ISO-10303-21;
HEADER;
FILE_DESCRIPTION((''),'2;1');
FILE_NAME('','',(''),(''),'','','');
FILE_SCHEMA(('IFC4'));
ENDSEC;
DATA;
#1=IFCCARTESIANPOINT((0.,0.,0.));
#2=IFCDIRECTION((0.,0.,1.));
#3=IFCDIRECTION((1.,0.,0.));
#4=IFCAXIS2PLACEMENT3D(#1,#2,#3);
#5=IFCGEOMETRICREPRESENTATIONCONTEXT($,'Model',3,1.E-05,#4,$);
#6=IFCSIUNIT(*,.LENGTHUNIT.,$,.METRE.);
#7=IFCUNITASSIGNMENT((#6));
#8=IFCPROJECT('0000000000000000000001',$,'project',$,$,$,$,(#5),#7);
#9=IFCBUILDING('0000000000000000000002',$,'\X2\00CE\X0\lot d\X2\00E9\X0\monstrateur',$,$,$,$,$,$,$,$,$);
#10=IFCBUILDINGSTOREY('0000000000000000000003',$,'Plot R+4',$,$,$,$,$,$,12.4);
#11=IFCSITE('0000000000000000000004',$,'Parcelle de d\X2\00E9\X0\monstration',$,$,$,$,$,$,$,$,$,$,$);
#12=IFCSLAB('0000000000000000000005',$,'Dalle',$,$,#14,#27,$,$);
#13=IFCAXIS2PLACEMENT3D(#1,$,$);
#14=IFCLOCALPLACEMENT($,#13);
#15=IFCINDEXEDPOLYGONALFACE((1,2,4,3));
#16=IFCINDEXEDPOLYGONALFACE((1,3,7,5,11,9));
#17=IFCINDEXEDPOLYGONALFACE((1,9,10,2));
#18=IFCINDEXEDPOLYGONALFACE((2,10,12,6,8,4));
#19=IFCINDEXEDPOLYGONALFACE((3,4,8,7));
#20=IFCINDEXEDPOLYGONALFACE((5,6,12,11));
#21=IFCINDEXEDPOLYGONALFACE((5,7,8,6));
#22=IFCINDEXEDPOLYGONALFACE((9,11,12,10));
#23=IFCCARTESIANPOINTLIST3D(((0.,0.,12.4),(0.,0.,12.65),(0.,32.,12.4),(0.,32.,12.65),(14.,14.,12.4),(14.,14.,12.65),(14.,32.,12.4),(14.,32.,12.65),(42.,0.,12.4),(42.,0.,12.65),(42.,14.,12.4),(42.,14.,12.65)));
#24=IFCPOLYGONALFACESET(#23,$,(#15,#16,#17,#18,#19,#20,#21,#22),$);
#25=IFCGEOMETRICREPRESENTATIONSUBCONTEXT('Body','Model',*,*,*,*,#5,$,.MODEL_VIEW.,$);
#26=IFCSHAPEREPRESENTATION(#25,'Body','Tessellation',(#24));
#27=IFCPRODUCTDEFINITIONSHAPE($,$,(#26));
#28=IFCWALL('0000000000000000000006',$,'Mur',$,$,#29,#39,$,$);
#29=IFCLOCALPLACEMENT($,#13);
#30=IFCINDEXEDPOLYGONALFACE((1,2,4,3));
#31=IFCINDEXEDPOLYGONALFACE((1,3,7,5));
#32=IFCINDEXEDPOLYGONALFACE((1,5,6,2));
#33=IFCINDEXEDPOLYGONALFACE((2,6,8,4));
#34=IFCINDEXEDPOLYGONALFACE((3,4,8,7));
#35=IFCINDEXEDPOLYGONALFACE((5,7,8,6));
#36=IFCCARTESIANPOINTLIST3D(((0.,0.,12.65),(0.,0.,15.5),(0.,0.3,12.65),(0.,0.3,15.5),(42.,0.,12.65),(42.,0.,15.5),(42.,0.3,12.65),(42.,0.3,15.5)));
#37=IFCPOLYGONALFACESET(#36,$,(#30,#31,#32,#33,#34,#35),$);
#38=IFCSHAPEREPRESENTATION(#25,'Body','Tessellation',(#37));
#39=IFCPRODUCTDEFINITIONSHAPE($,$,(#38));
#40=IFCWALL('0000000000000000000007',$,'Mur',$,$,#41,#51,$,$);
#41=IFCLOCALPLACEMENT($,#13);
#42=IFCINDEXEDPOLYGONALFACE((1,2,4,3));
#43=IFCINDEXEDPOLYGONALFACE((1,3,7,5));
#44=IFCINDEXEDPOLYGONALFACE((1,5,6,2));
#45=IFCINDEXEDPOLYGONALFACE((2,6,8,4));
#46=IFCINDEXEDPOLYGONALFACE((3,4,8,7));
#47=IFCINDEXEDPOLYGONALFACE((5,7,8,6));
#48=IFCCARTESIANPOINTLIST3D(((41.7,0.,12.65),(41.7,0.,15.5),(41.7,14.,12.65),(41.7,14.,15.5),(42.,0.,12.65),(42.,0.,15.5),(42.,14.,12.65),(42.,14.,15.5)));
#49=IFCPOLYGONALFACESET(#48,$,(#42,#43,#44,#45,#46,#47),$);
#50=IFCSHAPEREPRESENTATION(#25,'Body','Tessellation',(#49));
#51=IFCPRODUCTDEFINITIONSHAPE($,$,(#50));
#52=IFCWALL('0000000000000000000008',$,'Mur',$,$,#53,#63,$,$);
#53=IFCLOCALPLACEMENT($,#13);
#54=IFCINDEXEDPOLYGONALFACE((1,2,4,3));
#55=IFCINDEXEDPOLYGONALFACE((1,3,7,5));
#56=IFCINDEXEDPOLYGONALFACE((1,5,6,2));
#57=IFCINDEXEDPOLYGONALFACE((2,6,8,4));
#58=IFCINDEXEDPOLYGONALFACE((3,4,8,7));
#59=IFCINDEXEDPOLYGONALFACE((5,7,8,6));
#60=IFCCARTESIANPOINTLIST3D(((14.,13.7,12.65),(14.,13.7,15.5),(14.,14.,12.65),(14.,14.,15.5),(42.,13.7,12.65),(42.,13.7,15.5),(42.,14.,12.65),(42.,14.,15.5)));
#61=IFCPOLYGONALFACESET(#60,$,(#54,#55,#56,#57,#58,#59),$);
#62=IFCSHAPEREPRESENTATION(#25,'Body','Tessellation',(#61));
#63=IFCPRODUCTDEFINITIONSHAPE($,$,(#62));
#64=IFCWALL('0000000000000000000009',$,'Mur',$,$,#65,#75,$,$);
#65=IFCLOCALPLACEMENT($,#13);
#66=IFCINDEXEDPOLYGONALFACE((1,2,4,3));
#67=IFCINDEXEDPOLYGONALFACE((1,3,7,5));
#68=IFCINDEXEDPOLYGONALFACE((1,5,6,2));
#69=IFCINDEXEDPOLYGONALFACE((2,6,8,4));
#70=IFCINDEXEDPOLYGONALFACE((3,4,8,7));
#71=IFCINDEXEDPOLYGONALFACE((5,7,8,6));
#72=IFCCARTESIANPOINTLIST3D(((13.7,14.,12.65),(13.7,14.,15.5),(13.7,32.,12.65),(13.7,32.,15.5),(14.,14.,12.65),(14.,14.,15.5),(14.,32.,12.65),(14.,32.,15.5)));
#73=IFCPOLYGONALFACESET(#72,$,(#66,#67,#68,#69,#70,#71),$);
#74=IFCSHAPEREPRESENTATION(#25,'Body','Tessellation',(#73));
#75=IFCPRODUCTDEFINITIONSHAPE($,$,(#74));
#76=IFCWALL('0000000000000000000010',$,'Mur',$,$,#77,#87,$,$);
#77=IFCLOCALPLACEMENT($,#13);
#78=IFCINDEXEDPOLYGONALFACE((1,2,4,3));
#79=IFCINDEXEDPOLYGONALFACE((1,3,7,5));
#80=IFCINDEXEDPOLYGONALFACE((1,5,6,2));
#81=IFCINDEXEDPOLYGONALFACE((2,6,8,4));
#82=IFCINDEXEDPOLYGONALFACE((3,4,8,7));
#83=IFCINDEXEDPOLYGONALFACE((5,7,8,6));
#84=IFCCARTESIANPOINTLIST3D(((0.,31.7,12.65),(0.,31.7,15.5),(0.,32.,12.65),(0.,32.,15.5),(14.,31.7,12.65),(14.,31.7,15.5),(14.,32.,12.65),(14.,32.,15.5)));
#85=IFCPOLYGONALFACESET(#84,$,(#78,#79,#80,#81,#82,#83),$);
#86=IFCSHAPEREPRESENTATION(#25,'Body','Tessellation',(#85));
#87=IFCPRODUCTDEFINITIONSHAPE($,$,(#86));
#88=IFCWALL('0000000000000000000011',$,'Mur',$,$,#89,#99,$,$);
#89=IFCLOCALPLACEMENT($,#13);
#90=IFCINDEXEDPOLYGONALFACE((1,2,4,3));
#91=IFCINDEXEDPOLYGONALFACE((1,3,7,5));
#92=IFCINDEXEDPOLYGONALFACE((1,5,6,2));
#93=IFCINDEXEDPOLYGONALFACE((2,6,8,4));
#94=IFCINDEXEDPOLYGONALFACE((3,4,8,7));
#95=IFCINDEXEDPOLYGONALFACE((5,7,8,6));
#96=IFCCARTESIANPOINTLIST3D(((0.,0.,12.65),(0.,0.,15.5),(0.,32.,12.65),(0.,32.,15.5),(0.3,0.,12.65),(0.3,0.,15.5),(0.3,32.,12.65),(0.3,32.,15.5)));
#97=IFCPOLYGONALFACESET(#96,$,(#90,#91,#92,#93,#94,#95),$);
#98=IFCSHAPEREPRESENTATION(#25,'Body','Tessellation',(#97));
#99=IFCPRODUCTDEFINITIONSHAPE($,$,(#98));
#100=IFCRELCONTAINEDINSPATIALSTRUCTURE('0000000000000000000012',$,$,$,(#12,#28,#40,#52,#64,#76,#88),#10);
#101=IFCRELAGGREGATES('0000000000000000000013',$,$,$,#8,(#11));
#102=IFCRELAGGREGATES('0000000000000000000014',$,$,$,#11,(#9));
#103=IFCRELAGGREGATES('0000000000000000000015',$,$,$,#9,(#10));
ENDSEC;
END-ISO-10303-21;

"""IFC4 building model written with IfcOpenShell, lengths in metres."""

from ifc_helpers import new_model, si_unit, frame, origin_with_axes, place, context, subcontext, project, spatial, indexed_curve, outline, extrude, element, save


model = new_model("IFC4")

# Units and contexts
model_context = context("Model", 3, precision=1e-05, world=origin_with_axes())
body_context = subcontext(model_context, "Body", "Model", "MODEL_VIEW")
ifc_project = project(units=[si_unit("LENGTHUNIT", "METRE")], contexts=[model_context])

# Site, building, storey
site = spatial("IfcSite", under=ifc_project, Name="Parcelle de démonstration")
building = spatial("IfcBuilding", under=site, Name="Îlot démonstrateur")
storey = spatial("IfcBuildingStorey", under=building, Name="Plot R+4", Elevation=12.4)

# Slab
slab_placement = place(None, frame((0.0, 0.0, 12.4), z_axis=(0.0, 0.0, 1.0), x_axis=(1.0, 0.0, 0.0)))
element("IfcSlab", 1, at=slab_placement, inside=storey, Name="Dalle", context=body_context, shape_type="SweptSolid", body=[
    extrude(outline(indexed_curve([(0.0, 0.0), (42.0, 0.0), (42.0, 14.0), (14.0, 14.0), (14.0, 32.0), (0.0, 32.0)])), None, (0.0, 0.0, 1.0), 0.25),
])

# Walls
wall_1_placement = place(None, frame((0.0, 0.0, 12.65), z_axis=(0.0, 0.0, 1.0), x_axis=(1.0, 0.0, 0.0)))
element("IfcWall", 2, at=wall_1_placement, inside=storey, Name="Mur", context=body_context, shape_type="SweptSolid", body=[
    extrude(outline(indexed_curve([(0.0, 0.0), (0.0, 0.3), (42.0, 0.3), (42.0, 0.0), (0.0, 0.0)], self_intersect=False)), origin_with_axes(), (0.0, 0.0, 1.0), 2.85),
])
wall_2_placement = place(None, frame((42.0, 0.0, 12.65), z_axis=(0.0, 0.0, 1.0), x_axis=(0.0, 1.0, 0.0)))
element("IfcWall", 3, at=wall_2_placement, inside=storey, Name="Mur", context=body_context, shape_type="SweptSolid", body=[
    extrude(outline(indexed_curve([(0.0, 0.0), (0.0, 0.3), (14.0, 0.3), (14.0, 0.0), (0.0, 0.0)], self_intersect=False)), origin_with_axes(), (0.0, 0.0, 1.0), 2.85),
])
wall_3_placement = place(None, frame((42.0, 14.0, 12.65), z_axis=(0.0, 0.0, 1.0), x_axis=(-1.0, 0.0, 0.0)))
element("IfcWall", 4, at=wall_3_placement, inside=storey, Name="Mur", context=body_context, shape_type="SweptSolid", body=[
    extrude(outline(indexed_curve([(0.0, 0.0), (0.0, 0.3), (28.0, 0.3), (28.0, 0.0), (0.0, 0.0)], self_intersect=False)), origin_with_axes(), (0.0, 0.0, 1.0), 2.85),
])
wall_4_placement = place(None, frame((14.0, 14.0, 12.65), z_axis=(0.0, 0.0, 1.0), x_axis=(0.0, 1.0, 0.0)))
element("IfcWall", 5, at=wall_4_placement, inside=storey, Name="Mur", context=body_context, shape_type="SweptSolid", body=[
    extrude(outline(indexed_curve([(0.0, 0.0), (0.0, 0.3), (18.0, 0.3), (18.0, 0.0), (0.0, 0.0)], self_intersect=False)), origin_with_axes(), (0.0, 0.0, 1.0), 2.85),
])
wall_5_placement = place(None, frame((14.0, 32.0, 12.65), z_axis=(0.0, 0.0, 1.0), x_axis=(-1.0, 0.0, 0.0)))
element("IfcWall", 6, at=wall_5_placement, inside=storey, Name="Mur", context=body_context, shape_type="SweptSolid", body=[
    extrude(outline(indexed_curve([(0.0, 0.0), (0.0, 0.3), (14.0, 0.3), (14.0, 0.0), (0.0, 0.0)], self_intersect=False)), origin_with_axes(), (0.0, 0.0, 1.0), 2.85),
])
wall_6_placement = place(None, frame((0.0, 32.0, 12.65), z_axis=(0.0, 0.0, 1.0), x_axis=(0.0, -1.0, 0.0)))
element("IfcWall", 7, at=wall_6_placement, inside=storey, Name="Mur", context=body_context, shape_type="SweptSolid", body=[
    extrude(outline(indexed_curve([(0.0, 0.0), (0.0, 0.3), (32.0, 0.3), (32.0, 0.0), (0.0, 0.0)], self_intersect=False)), origin_with_axes(), (0.0, 0.0, 1.0), 2.85),
])

save(model, "model.ifc")
